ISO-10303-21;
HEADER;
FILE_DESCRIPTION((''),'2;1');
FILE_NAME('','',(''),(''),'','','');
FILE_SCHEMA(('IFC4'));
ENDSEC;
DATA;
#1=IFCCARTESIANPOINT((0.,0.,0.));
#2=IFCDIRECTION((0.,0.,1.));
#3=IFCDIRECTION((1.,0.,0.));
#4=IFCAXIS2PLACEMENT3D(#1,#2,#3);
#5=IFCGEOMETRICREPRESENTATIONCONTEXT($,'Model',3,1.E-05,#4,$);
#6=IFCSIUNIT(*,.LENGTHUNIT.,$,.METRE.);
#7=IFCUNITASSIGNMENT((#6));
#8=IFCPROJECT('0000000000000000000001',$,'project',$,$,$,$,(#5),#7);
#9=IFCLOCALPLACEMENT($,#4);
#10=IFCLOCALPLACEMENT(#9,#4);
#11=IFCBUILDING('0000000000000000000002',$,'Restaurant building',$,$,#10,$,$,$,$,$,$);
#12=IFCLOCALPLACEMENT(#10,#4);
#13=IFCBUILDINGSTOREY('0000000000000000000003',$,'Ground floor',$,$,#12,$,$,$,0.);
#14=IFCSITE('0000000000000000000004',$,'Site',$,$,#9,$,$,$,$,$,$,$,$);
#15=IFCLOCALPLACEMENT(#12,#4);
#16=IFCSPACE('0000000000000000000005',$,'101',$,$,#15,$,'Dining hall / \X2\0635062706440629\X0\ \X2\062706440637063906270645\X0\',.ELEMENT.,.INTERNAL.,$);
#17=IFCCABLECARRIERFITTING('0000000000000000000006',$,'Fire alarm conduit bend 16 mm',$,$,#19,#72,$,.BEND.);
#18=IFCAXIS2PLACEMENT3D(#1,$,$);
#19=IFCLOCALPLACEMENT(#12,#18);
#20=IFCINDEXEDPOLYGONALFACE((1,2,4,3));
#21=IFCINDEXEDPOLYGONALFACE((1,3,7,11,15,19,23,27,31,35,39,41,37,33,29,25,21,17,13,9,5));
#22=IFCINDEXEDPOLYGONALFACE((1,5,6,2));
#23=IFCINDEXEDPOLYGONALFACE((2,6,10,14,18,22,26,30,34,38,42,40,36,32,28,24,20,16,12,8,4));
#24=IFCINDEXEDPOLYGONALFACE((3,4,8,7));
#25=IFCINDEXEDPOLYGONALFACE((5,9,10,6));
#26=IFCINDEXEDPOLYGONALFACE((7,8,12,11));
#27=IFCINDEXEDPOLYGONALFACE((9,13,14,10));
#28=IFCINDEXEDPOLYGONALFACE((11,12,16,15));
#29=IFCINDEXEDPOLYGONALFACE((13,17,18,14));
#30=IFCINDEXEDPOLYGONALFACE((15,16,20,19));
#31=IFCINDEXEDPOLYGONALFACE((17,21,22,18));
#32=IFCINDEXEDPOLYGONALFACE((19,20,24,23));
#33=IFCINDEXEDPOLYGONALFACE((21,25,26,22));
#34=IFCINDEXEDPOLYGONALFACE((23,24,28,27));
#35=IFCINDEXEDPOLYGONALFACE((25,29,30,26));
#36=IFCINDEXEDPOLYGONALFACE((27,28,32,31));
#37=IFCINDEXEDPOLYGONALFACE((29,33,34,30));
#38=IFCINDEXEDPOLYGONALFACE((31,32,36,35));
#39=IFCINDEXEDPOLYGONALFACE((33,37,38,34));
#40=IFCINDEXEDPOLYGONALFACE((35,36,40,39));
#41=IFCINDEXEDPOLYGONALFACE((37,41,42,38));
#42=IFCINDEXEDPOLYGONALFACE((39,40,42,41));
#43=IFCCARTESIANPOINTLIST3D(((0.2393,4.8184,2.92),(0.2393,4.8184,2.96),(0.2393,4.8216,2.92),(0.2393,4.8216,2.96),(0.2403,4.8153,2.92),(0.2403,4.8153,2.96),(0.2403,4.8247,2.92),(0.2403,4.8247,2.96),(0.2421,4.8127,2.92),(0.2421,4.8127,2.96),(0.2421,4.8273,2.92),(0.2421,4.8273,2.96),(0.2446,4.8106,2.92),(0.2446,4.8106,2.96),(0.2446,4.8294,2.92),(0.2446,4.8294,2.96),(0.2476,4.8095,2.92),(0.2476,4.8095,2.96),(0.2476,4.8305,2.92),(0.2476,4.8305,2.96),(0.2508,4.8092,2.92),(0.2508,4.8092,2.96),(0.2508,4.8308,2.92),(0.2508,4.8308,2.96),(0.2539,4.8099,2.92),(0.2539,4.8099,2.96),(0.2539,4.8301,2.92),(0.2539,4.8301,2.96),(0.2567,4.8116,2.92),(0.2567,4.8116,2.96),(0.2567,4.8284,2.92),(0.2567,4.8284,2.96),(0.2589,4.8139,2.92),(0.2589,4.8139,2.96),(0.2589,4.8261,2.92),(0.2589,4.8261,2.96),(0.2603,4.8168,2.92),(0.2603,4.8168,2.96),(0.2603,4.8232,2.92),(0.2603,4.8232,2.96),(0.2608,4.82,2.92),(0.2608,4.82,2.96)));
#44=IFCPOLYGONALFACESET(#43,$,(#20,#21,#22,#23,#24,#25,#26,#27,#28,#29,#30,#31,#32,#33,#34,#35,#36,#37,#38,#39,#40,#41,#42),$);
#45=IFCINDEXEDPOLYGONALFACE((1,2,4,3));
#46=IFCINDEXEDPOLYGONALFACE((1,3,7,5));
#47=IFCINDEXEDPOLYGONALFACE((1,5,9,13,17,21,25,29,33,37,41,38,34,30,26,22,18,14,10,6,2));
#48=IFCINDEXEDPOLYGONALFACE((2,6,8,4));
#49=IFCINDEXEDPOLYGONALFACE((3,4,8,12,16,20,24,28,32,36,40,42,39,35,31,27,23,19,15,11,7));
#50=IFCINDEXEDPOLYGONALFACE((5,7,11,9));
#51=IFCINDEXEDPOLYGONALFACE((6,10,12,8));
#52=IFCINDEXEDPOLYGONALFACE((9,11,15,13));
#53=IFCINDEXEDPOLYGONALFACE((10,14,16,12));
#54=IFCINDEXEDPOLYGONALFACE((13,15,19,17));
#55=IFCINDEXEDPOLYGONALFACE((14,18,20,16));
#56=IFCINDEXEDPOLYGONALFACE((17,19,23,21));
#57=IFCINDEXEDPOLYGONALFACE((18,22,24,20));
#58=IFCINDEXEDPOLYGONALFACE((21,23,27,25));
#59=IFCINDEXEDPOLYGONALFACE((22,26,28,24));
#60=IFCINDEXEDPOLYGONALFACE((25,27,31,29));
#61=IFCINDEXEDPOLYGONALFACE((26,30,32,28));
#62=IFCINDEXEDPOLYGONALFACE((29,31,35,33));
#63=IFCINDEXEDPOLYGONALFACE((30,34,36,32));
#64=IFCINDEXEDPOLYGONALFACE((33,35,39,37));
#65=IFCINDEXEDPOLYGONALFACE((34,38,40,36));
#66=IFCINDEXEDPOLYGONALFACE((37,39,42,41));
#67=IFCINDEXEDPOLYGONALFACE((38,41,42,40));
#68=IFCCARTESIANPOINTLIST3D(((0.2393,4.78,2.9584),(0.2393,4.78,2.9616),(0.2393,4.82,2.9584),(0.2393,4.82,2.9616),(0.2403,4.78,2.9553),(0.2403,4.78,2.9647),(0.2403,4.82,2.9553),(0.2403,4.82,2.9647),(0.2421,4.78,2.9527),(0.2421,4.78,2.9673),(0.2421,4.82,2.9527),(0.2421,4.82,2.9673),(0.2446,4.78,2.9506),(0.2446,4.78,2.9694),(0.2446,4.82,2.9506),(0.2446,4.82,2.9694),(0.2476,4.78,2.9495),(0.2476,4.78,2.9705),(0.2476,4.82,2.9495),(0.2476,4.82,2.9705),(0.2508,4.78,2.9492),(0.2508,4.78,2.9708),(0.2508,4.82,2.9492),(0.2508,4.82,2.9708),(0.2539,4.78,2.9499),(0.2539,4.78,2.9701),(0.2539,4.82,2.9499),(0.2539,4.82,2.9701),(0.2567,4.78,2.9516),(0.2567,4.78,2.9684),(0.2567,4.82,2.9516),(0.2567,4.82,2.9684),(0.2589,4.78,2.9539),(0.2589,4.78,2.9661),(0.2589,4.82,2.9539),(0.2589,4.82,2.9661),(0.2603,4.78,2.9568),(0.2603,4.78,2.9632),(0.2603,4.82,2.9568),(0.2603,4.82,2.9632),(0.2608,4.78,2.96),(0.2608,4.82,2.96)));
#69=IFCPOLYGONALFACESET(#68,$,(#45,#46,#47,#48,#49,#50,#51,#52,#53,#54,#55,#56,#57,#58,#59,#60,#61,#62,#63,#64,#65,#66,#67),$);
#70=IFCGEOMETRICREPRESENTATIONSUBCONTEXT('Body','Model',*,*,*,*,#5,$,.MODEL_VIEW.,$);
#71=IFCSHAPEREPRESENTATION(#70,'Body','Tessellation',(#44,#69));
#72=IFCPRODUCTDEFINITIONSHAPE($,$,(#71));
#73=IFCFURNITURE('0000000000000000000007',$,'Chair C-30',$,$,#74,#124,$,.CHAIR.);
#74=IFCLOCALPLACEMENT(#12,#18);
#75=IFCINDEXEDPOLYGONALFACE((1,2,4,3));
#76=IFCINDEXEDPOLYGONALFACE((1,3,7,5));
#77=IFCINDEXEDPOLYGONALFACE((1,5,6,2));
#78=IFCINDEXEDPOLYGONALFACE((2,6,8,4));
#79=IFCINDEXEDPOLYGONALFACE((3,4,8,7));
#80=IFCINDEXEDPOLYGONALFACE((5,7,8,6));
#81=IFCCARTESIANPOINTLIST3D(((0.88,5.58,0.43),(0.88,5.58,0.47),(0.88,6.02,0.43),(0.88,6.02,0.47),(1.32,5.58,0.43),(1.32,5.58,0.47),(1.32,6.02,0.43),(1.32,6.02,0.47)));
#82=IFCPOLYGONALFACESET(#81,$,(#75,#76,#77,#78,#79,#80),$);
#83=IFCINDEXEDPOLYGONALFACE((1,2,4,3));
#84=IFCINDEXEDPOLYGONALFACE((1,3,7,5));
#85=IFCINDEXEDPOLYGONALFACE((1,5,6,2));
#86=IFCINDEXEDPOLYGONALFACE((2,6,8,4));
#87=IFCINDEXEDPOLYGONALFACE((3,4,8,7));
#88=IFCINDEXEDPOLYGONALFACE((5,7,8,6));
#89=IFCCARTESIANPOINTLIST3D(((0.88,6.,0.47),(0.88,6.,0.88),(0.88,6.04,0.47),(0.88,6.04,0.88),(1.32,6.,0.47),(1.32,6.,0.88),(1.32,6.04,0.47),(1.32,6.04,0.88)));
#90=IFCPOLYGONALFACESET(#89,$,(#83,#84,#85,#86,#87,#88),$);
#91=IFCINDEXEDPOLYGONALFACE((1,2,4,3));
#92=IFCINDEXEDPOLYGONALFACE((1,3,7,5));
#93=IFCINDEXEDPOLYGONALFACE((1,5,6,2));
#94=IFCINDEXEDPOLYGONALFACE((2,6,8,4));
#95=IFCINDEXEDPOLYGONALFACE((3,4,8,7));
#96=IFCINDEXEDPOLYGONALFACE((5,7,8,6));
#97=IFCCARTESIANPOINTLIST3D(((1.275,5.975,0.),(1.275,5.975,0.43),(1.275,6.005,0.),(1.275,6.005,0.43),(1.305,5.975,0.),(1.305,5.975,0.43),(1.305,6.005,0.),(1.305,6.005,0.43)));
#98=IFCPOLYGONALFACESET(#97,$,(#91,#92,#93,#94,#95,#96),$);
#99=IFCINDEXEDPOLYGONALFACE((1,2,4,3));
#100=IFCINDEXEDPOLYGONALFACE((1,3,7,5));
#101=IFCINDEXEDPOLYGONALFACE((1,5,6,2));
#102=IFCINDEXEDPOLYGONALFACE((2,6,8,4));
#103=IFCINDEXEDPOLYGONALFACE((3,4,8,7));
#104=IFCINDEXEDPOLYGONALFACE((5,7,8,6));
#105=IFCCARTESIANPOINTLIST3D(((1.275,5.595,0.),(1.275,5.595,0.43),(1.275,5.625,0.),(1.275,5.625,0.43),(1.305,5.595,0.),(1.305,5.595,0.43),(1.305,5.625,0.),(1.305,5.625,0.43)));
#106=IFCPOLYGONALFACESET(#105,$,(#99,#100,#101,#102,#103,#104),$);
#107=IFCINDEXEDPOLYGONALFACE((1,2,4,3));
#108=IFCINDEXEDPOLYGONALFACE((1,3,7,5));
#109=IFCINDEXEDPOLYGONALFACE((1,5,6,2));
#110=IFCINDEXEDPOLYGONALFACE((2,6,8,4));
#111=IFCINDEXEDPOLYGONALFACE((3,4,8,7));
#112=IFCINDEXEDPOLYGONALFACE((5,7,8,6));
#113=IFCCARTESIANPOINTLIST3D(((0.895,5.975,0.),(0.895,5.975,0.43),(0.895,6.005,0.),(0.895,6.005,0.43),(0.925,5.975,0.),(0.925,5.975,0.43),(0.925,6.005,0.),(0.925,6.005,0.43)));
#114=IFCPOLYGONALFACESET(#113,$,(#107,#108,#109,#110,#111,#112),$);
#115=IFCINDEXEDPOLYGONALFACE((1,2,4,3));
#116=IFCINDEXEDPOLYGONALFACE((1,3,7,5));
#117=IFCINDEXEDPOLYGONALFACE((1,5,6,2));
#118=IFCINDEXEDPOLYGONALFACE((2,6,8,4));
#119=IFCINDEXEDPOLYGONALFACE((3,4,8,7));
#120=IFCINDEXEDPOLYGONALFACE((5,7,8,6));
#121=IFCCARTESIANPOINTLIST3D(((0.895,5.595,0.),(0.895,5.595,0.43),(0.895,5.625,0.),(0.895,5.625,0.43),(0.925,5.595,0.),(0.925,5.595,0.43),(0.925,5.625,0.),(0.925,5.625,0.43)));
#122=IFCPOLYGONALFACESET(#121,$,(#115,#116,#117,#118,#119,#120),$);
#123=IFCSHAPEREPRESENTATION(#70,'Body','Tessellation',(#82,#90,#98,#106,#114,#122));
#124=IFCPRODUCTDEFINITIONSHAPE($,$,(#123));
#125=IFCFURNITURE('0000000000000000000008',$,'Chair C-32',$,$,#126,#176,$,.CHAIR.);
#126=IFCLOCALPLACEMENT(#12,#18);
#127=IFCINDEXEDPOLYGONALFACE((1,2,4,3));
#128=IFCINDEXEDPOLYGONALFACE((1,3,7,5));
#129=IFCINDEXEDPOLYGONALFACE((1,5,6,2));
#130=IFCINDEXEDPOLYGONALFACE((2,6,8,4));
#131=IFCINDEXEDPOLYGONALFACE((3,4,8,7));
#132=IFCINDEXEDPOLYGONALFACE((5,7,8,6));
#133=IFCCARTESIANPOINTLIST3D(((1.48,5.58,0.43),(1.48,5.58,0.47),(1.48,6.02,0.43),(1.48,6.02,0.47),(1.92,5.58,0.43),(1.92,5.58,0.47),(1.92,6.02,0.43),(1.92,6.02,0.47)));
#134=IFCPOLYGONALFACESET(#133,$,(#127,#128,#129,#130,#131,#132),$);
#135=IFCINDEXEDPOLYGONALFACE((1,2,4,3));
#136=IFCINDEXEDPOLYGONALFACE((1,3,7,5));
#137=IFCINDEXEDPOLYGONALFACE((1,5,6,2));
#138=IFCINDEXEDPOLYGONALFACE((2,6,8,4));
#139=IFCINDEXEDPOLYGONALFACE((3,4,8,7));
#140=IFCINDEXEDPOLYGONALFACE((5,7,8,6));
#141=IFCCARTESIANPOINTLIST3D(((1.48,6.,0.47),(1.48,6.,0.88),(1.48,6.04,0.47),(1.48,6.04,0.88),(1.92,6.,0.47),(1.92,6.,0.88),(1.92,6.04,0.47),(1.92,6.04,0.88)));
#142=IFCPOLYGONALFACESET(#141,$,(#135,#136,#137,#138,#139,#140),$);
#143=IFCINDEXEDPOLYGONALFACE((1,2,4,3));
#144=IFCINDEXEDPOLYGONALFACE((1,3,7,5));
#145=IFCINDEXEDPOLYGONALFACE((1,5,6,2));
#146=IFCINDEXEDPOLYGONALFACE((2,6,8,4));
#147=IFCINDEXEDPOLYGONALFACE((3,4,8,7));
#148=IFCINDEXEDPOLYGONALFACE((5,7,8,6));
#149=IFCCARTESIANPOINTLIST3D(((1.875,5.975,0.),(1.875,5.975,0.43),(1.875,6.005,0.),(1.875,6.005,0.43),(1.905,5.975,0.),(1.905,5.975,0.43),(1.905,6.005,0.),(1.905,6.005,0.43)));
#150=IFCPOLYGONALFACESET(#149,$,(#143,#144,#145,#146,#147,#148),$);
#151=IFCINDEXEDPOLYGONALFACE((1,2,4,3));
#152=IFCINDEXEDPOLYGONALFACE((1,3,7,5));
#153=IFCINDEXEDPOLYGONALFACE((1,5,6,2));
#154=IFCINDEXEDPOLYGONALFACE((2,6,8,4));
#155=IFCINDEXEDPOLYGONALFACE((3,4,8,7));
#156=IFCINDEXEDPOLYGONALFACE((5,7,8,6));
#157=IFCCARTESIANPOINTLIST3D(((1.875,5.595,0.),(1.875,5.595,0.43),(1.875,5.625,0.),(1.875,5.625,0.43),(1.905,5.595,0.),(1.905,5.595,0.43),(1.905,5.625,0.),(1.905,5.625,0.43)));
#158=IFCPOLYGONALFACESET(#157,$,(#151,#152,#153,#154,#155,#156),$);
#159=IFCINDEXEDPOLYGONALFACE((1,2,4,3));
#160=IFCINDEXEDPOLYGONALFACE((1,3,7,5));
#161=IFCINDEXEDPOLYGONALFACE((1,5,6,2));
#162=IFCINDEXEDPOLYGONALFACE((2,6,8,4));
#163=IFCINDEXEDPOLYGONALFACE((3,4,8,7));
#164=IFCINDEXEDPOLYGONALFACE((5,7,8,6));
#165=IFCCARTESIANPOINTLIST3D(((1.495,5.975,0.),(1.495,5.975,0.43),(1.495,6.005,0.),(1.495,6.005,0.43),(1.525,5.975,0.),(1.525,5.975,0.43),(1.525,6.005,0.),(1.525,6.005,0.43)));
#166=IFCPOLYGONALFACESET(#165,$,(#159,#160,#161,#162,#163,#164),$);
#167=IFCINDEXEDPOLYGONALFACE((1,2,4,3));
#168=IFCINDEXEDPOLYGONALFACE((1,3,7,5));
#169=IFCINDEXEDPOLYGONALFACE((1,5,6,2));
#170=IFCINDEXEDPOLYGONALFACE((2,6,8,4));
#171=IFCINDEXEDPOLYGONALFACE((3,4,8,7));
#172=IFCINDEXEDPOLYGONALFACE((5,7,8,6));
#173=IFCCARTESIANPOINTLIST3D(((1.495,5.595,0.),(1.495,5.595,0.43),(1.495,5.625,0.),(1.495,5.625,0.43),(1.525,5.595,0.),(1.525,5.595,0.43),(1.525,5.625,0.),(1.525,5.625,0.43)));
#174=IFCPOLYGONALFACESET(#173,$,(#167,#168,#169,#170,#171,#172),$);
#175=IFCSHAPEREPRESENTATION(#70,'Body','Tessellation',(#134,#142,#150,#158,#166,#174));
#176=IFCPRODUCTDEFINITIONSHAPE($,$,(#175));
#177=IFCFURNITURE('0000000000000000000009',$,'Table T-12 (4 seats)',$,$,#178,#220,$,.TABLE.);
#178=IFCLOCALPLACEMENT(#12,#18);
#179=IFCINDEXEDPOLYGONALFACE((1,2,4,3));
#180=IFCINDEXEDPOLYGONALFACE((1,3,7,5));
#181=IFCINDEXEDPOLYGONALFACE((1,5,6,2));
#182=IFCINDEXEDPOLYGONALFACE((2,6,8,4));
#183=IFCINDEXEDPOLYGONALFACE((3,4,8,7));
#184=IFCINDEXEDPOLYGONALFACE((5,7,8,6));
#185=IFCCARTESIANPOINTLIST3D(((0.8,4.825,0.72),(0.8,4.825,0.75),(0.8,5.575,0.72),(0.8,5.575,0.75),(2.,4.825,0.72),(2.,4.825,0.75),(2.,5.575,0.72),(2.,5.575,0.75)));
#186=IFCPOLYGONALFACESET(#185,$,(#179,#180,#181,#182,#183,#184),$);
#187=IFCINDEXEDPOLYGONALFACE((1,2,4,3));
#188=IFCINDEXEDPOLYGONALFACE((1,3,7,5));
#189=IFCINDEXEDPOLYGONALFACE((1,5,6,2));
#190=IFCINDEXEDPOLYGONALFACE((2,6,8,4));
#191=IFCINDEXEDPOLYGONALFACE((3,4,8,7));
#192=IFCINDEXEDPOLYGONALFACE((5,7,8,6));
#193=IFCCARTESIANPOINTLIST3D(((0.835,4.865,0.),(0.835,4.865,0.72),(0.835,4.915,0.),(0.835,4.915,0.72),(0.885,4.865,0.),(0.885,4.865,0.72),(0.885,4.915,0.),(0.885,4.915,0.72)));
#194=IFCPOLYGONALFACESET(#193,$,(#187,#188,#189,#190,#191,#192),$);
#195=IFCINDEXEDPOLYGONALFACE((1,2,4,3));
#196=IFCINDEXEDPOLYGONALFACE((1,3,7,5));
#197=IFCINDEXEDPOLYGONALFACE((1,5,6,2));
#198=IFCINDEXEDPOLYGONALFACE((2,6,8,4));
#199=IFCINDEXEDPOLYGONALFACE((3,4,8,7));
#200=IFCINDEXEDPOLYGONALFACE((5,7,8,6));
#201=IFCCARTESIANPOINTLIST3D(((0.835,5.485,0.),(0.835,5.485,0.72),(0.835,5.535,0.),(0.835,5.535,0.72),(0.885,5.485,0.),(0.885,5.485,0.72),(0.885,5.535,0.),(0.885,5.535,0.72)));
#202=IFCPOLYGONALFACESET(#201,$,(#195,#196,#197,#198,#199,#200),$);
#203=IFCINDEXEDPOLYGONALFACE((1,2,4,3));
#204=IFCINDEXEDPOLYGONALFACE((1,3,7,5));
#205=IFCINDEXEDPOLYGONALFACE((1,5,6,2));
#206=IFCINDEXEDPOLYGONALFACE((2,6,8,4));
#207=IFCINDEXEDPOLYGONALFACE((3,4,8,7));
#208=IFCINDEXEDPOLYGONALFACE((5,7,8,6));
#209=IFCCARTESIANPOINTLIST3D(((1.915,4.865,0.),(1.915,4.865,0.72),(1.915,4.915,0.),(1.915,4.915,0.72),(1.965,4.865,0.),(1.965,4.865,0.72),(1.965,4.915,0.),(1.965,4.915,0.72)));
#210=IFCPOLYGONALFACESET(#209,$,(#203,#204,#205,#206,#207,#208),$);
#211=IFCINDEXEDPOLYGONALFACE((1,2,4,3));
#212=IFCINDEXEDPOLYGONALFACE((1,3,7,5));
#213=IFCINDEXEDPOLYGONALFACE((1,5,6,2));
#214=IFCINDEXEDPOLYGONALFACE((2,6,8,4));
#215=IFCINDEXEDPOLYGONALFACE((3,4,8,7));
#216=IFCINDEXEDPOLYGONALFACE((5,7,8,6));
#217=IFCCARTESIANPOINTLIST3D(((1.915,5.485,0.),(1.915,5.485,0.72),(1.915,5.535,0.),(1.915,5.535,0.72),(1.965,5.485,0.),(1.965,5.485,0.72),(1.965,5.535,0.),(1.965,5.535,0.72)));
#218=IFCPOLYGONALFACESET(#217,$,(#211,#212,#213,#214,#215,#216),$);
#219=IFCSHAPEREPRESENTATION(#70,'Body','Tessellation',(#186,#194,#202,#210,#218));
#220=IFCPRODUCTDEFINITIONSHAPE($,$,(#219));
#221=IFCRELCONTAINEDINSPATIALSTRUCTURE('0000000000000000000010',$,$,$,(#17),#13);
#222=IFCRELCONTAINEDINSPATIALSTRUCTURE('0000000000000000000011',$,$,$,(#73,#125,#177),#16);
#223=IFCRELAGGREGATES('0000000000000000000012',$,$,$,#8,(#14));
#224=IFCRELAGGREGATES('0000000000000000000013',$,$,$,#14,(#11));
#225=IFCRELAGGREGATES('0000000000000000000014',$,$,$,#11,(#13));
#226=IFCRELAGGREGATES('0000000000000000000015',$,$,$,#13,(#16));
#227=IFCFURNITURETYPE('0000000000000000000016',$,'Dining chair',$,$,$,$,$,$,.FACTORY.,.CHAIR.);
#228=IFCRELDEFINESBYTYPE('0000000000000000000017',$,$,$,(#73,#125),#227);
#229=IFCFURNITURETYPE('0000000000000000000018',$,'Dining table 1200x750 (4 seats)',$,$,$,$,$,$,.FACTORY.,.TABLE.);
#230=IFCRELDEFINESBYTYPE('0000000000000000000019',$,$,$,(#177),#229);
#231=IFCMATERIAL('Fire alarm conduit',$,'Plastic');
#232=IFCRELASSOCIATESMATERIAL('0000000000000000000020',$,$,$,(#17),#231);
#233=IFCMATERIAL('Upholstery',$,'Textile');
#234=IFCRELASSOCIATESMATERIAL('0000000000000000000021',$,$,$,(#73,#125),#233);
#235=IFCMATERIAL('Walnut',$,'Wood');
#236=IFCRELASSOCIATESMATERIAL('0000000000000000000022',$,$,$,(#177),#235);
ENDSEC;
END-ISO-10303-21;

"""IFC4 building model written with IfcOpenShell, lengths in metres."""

from ifc_helpers import new_model, si_unit, frame, origin, origin_with_axes, origin_2d, place, context, subcontext, project, spatial, rectangle, circle, extrude, source, transform, mapped, material, type_object, type_shapes, element, save


model = new_model("IFC4")

# Units and contexts
model_context = context("Model", 3, precision=1e-05, world=origin_with_axes())
body_context = subcontext(model_context, "Body", "Model", "MODEL_VIEW")
ifc_project = project(units=[si_unit("LENGTHUNIT", "METRE")], contexts=[model_context])

# Site, building, storey, space
site_placement = place(None, origin_with_axes())
site = spatial("IfcSite", under=ifc_project, at=site_placement, Name="Site")
building_placement = place(site_placement, origin_with_axes())
building = spatial("IfcBuilding", under=site, at=building_placement, Name="Restaurant building")
storey_placement = place(building_placement, origin_with_axes())
storey = spatial("IfcBuildingStorey", under=building, at=storey_placement, Name="Ground floor", Elevation=0.0)
space_placement = place(storey_placement, origin_with_axes())
space = spatial("IfcSpace", under=storey, at=space_placement, Name="101", LongName="Dining hall / صالة الطعام", CompositionType="ELEMENT", PredefinedType="INTERNAL")

# Shared definitions
ifc_material_1 = material(Name="Fire alarm conduit", Category="Plastic")

# Cable carrier fitting
cable_carrier_fitting_1_placement = place(storey_placement, frame((0.25, 4.82, 2.96)))
element("IfcCableCarrierFitting", 1, at=cable_carrier_fitting_1_placement, inside=storey, material=ifc_material_1, Name="Fire alarm conduit bend 16 mm", PredefinedType="BEND", context=body_context, shape_type="SweptSolid", body=[
    extrude(circle(Radius=0.0108, at=origin_2d()), frame((0.0, 0.0, 0.0), z_axis=(0.0, 0.0, -1.0), x_axis=(1.0, 0.0, 0.0)), (0.0, 0.0, 1.0), 0.04),
    extrude(circle(Radius=0.0108, at=origin_2d()), frame((0.0, 0.0, 0.0), z_axis=(0.0, -1.0, 0.0), x_axis=(1.0, 0.0, 0.0)), (0.0, 0.0, 1.0), 0.04),
])

# Furniture
ifc_material_2 = material(Name="Upholstery", Category="Textile")
furniture_type_1 = type_object("IfcFurnitureType", Name="Dining chair", AssemblyPlace="FACTORY", PredefinedType="CHAIR")
shared_shape_1 = source(origin(), body_context, "Body", "SweptSolid", [
    extrude(rectangle(XDim=0.44, YDim=0.44, at=origin_2d()), frame((0.0, 0.0, 0.43)), (0.0, 0.0, 1.0), 0.04),
    extrude(rectangle(XDim=0.44, YDim=0.04, at=origin_2d()), frame((0.0, -0.22, 0.47)), (0.0, 0.0, 1.0), 0.41),
    extrude(rectangle(XDim=0.03, YDim=0.03, at=origin_2d()), frame((-0.19, -0.19, 0.0)), (0.0, 0.0, 1.0), 0.43),
    extrude(rectangle(XDim=0.03, YDim=0.03, at=origin_2d()), frame((-0.19, 0.19, 0.0)), (0.0, 0.0, 1.0), 0.43),
    extrude(rectangle(XDim=0.03, YDim=0.03, at=origin_2d()), frame((0.19, -0.19, 0.0)), (0.0, 0.0, 1.0), 0.43),
    extrude(rectangle(XDim=0.03, YDim=0.03, at=origin_2d()), frame((0.19, 0.19, 0.0)), (0.0, 0.0, 1.0), 0.43),
])
type_shapes(furniture_type_1, [shared_shape_1])
for number, where, z_axis, x_axis, name in (
    (2, (1.1, 5.8, 0.0), (0.0, 0.0, 1.0), (-1.0, 0.0, 0.0), "Chair C-30"),
    (3, (1.7, 5.8, 0.0), (0.0, 0.0, 1.0), (-1.0, 0.0, 0.0), "Chair C-32"),
):
    element("IfcFurniture", number, at=place(storey_placement, frame(where, z_axis=z_axis, x_axis=x_axis)), inside=space, type_object=furniture_type_1, material=ifc_material_2, Name=name, PredefinedType="CHAIR", context=body_context, shape_type="MappedRepresentation", body=[
        mapped(shared_shape_1, transform((0.0, 0.0, 0.0))),
    ])
ifc_material_3 = material(Name="Walnut", Category="Wood")
furniture_type_2 = type_object("IfcFurnitureType", Name="Dining table 1200x750 (4 seats)", AssemblyPlace="FACTORY", PredefinedType="TABLE")
shared_shape_2 = source(origin(), body_context, "Body", "SweptSolid", [
    extrude(rectangle(XDim=1.2, YDim=0.75, at=origin_2d()), frame((0.0, 0.0, 0.72)), (0.0, 0.0, 1.0), 0.03),
    extrude(rectangle(XDim=0.05, YDim=0.05, at=origin_2d()), frame((-0.54, -0.31, 0.0)), (0.0, 0.0, 1.0), 0.72),
    extrude(rectangle(XDim=0.05, YDim=0.05, at=origin_2d()), frame((-0.54, 0.31, 0.0)), (0.0, 0.0, 1.0), 0.72),
    extrude(rectangle(XDim=0.05, YDim=0.05, at=origin_2d()), frame((0.54, -0.31, 0.0)), (0.0, 0.0, 1.0), 0.72),
    extrude(rectangle(XDim=0.05, YDim=0.05, at=origin_2d()), frame((0.54, 0.31, 0.0)), (0.0, 0.0, 1.0), 0.72),
])
type_shapes(furniture_type_2, [shared_shape_2])
furniture_placement = place(storey_placement, frame((1.4, 5.2, 0.0)))
element("IfcFurniture", 4, at=furniture_placement, inside=space, type_object=furniture_type_2, material=ifc_material_3, Name="Table T-12 (4 seats)", PredefinedType="TABLE", context=body_context, shape_type="MappedRepresentation", body=[
    mapped(shared_shape_2, transform((0.0, 0.0, 0.0))),
])

save(model, "model.ifc")
